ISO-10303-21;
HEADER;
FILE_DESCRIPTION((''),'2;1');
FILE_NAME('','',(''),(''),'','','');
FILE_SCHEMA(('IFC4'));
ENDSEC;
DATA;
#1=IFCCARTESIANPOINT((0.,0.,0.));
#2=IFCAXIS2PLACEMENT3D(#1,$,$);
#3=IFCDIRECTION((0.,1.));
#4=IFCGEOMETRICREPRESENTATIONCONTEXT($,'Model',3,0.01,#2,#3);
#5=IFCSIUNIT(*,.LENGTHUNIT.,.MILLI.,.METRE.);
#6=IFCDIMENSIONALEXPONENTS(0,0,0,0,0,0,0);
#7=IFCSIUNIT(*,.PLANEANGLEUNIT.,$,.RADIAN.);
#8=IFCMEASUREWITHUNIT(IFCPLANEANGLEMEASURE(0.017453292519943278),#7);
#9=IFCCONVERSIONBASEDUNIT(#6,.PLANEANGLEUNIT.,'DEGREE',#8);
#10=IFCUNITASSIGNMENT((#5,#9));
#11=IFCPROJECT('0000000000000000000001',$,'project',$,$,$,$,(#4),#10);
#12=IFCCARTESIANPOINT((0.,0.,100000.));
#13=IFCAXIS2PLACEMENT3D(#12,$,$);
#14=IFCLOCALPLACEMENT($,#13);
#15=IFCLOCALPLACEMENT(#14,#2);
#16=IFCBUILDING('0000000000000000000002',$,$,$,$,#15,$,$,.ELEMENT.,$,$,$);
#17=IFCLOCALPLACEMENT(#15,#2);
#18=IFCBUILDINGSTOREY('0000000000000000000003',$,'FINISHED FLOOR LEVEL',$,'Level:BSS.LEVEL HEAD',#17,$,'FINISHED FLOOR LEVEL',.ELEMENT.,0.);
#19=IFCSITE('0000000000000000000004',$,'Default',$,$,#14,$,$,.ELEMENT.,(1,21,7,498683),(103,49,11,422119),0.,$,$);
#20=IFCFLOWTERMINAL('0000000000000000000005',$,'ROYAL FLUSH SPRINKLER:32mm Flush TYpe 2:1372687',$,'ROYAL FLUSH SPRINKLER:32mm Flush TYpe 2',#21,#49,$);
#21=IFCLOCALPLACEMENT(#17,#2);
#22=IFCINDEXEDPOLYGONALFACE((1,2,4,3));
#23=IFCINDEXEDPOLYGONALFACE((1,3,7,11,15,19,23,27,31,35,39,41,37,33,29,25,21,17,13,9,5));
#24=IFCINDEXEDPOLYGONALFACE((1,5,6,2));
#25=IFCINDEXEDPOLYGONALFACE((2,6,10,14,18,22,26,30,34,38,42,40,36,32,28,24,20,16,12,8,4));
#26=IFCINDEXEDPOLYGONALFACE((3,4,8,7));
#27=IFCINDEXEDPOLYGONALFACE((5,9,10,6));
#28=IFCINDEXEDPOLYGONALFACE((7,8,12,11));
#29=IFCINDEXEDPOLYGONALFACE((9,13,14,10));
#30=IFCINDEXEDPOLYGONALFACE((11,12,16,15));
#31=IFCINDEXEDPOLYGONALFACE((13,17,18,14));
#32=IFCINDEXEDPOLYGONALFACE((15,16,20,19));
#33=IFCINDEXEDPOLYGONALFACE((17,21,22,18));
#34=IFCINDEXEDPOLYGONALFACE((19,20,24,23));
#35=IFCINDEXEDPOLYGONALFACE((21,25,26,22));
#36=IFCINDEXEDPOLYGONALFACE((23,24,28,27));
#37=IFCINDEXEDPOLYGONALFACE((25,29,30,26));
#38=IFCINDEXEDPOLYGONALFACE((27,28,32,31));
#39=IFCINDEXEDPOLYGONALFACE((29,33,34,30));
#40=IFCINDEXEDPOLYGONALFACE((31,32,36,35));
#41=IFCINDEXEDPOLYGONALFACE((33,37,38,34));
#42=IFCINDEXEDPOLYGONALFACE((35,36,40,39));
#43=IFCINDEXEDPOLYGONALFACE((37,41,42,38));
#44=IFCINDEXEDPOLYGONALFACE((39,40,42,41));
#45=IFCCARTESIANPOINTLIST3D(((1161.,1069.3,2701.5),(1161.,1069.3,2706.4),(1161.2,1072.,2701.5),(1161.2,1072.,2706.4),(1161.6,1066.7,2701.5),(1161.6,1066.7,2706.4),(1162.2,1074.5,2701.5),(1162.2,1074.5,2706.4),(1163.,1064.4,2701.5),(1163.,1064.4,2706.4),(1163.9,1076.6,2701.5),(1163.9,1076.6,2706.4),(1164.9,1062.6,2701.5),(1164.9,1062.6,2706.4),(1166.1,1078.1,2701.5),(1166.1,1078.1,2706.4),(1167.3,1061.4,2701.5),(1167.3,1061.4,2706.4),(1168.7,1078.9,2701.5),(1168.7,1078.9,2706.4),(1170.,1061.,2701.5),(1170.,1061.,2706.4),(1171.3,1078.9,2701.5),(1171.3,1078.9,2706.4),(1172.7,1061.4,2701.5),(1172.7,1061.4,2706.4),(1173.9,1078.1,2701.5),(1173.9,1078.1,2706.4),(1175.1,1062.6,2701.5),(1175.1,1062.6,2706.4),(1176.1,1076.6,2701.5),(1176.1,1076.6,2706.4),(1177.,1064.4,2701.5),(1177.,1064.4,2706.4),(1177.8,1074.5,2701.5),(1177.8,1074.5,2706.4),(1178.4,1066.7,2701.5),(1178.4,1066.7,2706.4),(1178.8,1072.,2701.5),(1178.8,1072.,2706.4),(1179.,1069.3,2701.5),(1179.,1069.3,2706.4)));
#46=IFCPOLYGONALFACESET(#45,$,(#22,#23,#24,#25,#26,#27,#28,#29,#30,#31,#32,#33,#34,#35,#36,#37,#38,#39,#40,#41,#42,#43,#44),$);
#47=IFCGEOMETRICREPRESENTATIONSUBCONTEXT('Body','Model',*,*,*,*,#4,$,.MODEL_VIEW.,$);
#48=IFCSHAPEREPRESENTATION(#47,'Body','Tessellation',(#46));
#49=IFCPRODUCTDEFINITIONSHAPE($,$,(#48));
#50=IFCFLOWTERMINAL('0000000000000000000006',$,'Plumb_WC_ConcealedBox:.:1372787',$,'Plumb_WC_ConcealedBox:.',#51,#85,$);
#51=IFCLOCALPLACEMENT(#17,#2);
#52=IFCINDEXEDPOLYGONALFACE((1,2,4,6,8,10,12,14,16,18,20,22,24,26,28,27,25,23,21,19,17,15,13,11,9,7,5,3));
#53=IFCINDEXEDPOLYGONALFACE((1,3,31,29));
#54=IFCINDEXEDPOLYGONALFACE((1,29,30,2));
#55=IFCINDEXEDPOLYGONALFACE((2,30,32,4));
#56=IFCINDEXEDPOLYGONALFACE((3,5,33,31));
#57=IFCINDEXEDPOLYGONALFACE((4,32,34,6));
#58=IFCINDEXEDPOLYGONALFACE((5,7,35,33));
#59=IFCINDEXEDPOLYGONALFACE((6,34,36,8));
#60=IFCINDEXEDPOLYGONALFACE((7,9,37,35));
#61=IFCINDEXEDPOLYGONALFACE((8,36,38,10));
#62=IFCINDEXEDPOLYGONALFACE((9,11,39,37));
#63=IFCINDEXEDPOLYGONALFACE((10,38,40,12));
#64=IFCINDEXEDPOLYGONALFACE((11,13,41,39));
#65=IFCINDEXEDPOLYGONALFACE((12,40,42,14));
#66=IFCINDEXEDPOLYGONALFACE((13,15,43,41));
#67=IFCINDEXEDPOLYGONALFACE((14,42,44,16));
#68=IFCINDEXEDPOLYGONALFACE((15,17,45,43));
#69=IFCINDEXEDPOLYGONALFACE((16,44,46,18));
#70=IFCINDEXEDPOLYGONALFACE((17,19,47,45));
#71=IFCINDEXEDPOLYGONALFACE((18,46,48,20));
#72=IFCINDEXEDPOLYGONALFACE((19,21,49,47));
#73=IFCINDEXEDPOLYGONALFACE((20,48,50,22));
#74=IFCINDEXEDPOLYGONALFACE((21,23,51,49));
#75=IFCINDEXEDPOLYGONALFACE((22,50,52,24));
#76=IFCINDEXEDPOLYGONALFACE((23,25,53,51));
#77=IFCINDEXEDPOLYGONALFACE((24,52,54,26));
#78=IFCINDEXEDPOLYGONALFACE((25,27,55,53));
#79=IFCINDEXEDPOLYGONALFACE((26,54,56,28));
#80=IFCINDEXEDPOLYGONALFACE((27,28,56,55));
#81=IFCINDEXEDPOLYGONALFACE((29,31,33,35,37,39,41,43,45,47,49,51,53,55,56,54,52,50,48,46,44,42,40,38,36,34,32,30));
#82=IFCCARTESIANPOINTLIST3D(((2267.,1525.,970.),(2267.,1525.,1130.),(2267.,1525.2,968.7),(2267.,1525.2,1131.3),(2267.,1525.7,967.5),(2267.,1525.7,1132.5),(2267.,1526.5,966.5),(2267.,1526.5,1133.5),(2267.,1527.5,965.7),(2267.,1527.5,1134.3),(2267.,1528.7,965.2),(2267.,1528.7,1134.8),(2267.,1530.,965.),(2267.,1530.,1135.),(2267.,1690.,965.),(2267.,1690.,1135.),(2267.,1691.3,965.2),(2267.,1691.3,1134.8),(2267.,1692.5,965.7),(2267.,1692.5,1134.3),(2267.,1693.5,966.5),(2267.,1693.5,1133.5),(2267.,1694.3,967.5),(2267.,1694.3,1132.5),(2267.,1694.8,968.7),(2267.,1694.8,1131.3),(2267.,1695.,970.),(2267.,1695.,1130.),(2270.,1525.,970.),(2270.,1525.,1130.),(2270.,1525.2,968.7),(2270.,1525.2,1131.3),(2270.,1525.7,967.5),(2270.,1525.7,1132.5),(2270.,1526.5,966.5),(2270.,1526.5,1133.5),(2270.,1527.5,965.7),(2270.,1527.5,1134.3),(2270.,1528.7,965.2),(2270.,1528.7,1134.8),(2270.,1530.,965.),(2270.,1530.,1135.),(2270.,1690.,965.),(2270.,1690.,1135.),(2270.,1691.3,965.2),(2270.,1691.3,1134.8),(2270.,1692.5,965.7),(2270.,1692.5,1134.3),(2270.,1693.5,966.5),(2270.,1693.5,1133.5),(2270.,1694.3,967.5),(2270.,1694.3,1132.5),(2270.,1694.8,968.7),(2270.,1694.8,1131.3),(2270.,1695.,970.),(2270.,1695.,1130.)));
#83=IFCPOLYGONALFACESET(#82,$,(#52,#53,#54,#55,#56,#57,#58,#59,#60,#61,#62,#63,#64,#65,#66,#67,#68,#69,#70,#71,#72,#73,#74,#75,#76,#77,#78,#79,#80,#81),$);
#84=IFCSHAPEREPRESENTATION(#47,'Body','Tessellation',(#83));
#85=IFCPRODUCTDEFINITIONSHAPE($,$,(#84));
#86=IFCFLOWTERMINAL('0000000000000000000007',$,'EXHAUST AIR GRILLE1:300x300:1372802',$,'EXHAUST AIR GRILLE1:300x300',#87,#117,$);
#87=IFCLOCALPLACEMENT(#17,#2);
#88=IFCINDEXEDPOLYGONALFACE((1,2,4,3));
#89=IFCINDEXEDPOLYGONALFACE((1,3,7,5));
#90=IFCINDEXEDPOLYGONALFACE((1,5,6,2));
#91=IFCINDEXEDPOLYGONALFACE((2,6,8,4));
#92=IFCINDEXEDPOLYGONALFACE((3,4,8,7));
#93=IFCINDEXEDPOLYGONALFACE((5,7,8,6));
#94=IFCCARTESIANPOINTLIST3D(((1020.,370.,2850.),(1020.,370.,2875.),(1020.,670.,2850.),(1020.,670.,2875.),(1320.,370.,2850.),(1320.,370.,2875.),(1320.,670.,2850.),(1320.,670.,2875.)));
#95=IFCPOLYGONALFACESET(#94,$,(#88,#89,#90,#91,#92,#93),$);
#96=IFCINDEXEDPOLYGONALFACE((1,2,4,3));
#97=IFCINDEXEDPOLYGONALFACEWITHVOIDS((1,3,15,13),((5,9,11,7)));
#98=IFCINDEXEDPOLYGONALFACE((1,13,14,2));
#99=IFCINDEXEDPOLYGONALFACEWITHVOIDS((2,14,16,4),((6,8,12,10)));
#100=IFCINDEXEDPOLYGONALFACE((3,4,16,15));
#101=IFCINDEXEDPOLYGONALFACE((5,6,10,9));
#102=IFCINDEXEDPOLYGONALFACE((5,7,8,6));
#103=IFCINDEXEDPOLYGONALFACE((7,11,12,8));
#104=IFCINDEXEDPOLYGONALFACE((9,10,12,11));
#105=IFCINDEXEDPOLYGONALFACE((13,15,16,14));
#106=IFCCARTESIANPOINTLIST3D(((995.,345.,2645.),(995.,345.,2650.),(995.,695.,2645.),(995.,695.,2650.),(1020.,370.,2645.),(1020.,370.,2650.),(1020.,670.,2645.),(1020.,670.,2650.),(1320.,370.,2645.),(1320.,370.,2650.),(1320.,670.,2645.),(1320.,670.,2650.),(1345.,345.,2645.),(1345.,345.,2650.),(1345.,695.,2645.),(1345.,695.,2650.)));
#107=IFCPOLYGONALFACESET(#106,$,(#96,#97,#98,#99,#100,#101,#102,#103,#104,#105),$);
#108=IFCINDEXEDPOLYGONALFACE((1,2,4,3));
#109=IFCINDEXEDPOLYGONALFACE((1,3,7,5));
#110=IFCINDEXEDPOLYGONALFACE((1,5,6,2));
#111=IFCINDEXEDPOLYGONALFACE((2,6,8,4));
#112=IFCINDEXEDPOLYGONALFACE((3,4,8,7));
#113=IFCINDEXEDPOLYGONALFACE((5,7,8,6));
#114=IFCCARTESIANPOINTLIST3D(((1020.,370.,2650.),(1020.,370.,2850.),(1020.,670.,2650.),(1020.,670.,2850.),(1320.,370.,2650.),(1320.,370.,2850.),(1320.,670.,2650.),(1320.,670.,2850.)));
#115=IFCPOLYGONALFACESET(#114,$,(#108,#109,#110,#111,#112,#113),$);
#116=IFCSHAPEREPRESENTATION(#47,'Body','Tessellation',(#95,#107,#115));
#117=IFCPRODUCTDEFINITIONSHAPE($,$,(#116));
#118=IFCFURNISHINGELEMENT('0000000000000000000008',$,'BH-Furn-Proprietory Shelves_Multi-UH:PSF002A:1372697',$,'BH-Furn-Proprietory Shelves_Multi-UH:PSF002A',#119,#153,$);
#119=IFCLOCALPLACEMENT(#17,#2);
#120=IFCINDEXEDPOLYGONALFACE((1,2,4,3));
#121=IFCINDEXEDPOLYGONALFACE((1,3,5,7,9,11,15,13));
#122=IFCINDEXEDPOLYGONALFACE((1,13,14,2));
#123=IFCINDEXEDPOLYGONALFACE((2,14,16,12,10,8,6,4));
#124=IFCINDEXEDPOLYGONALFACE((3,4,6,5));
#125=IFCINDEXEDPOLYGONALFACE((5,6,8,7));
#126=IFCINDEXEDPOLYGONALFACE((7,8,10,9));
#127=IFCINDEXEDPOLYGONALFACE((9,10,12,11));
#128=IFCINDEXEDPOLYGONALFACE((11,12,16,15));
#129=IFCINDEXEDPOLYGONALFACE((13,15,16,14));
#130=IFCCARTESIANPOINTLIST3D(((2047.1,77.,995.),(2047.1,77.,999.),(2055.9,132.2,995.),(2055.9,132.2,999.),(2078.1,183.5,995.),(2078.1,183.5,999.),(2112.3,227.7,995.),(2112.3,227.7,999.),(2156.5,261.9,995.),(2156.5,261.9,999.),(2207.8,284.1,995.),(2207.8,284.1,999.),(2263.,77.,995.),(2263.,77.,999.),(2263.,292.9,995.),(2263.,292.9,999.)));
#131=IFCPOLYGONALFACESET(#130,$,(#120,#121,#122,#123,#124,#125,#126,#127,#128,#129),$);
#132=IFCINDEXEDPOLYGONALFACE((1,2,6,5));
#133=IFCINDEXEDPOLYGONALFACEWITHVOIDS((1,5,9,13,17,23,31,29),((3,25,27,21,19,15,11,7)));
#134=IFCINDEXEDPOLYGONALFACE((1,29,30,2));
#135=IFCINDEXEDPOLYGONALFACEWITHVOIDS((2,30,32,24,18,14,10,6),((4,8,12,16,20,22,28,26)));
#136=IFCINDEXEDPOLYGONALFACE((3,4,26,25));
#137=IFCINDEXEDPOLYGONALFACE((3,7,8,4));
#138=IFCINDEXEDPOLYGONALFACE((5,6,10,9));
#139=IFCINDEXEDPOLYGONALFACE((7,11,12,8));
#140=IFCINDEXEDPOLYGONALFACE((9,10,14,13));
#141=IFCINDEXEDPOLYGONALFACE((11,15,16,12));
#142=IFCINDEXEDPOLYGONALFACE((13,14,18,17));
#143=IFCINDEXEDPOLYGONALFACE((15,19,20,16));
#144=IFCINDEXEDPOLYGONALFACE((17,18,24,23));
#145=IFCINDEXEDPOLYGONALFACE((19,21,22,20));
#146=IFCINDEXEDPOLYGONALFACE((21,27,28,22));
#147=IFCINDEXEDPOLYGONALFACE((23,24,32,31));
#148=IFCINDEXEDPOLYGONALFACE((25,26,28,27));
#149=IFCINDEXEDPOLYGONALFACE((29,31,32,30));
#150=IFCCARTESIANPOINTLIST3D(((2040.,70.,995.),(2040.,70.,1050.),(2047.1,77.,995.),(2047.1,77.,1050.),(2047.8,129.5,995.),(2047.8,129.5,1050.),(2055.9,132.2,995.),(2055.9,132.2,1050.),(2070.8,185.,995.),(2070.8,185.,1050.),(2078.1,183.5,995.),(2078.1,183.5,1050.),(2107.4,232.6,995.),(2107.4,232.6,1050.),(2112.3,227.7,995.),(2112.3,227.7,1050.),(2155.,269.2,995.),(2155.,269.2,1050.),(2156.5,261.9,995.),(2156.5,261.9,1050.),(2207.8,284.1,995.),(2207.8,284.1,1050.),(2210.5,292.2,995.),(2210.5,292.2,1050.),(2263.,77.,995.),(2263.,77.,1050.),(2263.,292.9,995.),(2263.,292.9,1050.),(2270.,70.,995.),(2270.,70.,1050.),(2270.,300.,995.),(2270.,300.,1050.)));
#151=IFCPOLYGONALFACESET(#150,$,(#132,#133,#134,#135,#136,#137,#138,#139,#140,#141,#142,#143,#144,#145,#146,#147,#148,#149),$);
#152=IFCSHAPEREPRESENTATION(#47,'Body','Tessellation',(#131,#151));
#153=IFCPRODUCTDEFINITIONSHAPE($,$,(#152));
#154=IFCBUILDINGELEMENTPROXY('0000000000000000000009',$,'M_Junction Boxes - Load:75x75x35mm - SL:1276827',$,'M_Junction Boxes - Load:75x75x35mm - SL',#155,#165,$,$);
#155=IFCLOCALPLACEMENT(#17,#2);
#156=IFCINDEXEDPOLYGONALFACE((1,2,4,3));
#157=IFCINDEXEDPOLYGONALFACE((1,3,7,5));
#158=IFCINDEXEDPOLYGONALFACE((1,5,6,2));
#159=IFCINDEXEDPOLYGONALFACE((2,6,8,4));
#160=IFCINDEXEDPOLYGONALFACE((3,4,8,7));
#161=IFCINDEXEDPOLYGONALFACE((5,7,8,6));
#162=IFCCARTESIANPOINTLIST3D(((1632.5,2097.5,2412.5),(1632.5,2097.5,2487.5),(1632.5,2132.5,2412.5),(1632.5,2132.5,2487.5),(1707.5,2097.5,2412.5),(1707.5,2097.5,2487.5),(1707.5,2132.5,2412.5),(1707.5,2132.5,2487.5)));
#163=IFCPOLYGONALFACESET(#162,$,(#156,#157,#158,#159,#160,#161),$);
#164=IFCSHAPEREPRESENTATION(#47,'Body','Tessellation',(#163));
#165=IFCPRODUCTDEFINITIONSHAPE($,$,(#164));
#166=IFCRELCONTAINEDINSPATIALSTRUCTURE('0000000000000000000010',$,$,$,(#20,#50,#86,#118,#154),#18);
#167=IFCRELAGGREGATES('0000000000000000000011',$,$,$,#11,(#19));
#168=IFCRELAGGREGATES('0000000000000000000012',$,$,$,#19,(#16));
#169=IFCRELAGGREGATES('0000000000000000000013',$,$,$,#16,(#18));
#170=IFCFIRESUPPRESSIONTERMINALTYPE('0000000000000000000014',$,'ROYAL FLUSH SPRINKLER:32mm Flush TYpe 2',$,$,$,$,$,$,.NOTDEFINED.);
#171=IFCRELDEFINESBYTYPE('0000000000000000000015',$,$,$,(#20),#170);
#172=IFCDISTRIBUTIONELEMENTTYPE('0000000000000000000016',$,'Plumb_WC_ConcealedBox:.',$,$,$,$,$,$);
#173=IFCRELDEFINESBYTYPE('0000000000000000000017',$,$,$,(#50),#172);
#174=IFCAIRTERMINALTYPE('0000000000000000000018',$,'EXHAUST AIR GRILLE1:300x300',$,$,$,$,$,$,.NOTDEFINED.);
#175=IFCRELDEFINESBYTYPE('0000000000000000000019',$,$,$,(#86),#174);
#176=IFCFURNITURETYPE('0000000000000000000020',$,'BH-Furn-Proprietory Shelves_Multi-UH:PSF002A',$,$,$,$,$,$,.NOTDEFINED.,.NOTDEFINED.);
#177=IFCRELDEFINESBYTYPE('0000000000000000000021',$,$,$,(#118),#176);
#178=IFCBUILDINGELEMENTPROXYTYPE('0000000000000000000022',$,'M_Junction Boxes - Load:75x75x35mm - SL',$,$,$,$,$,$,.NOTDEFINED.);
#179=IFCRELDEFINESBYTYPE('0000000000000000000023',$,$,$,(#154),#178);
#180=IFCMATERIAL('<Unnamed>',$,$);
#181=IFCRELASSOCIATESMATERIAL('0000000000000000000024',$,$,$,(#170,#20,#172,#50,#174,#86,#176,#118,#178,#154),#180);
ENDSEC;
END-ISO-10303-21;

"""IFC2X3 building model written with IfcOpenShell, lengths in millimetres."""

from ifc_helpers import new_model, entity, si_unit, converted_unit, direction, frame, frame_2d, origin, origin_2d_with_axis, place, context, subcontext, project, spatial, polyline, circle_curve, parameter, trimmed, segment, composite_curve, rectangle, circle, outline, extrude, source, transform, mapped, material, type_object, type_shapes, element, save


model = new_model("IFC2X3")

# Units and contexts
model_context = context("Model", 3, precision=0.01, world=origin(), true_north=direction((0.0, 1.0)))
body_context = subcontext(model_context, "Body", "Model", "MODEL_VIEW")
ifc_project = project(units=[si_unit("LENGTHUNIT", "METRE", prefix="MILLI"), converted_unit("PLANEANGLEUNIT", "DEGREE", entity("IfcPlaneAngleMeasure", 0.017453292519943278), si_unit("PLANEANGLEUNIT", "RADIAN"), dimensions=[0, 0, 0, 0, 0, 0, 0])], contexts=[model_context])

# Site, building, storey
site_placement = place(None, frame((0.0, 0.0, 100000.0)))
site = spatial("IfcSite", under=ifc_project, at=site_placement, Name="Default", CompositionType="ELEMENT", RefLatitude=(1, 21, 7, 498683), RefLongitude=(103, 49, 11, 422119), RefElevation=0.0)
building_placement = place(site_placement, origin())
building = spatial("IfcBuilding", under=site, at=building_placement, CompositionType="ELEMENT")
storey_placement = place(building_placement, origin())
storey = spatial("IfcBuildingStorey", under=building, at=storey_placement, Name="FINISHED FLOOR LEVEL", ObjectType="Level:BSS.LEVEL HEAD", LongName="FINISHED FLOOR LEVEL", CompositionType="ELEMENT", Elevation=0.0)

# Shared definitions
ifc_material_1 = material(Name="<Unnamed>")

# Flow terminals
fire_suppression_terminal_type = type_object("IfcFireSuppressionTerminalType", Name="ROYAL FLUSH SPRINKLER:32mm Flush TYpe 2", PredefinedType="NOTDEFINED", material=ifc_material_1)
shared_shape_1 = source(origin(), body_context, "Body", "SweptSolid", [
    extrude(circle(Radius=9.0, at=frame_2d((0.0, 0.0), x_axis=(1.0, 0.0))), frame((0.0, 0.0, 0.0), z_axis=(0.0, 0.0, 1.0), x_axis=(0.0, -1.0, 0.0)), (0.0, 0.0, 1.0), 5.0),
])
type_shapes(fire_suppression_terminal_type, [shared_shape_1])
flow_terminal_1_placement = place(storey_placement, frame((1170.0, 1070.0, 2701.5)))
element("IfcFlowTerminal", 1, at=flow_terminal_1_placement, inside=storey, type_object=fire_suppression_terminal_type, material=ifc_material_1, Name="ROYAL FLUSH SPRINKLER:32mm Flush TYpe 2:1372687", ObjectType="ROYAL FLUSH SPRINKLER:32mm Flush TYpe 2", context=body_context, shape_type="MappedRepresentation", body=[
    mapped(shared_shape_1, transform((0.0, 0.0, 0.0), scale=1.0)),
])
distribution_element_type_1 = type_object("IfcDistributionElementType", Name="Plumb_WC_ConcealedBox:.", material=ifc_material_1)
shared_shape_2 = source(origin(), body_context, "Body", "SweptSolid", [
    extrude(outline(composite_curve([segment(trimmed(circle_curve(frame_2d((80.0, -80.0), x_axis=(1.0, 0.0)), 5.0), [parameter(270.0)], [parameter(0.0)], True, "PARAMETER"), True, "CONTINUOUS"), segment(polyline([(85.0, -80.0), (85.0, 80.0)]), True, "CONTINUOUS"), segment(trimmed(circle_curve(frame_2d((80.0, 80.0), x_axis=(1.0, 0.0)), 5.0), [parameter(0.0)], [parameter(90.0)], True, "PARAMETER"), True, "CONTINUOUS"), segment(polyline([(80.0, 85.0), (-80.0, 85.0)]), True, "CONTINUOUS"), segment(trimmed(circle_curve(frame_2d((-80.0, 80.0), x_axis=(1.0, 0.0)), 5.0), [parameter(90.0)], [parameter(180.0)], True, "PARAMETER"), True, "CONTINUOUS"), segment(polyline([(-85.0, 80.0), (-85.0, -80.0)]), True, "CONTINUOUS"), segment(trimmed(circle_curve(frame_2d((-80.0, -80.0), x_axis=(1.0, 0.0)), 5.0), [parameter(180.0)], [parameter(270.0)], True, "PARAMETER"), True, "CONTINUOUS"), segment(polyline([(-80.0, -85.0), (80.0, -85.0)]), True, "CONTINUOUS")], self_intersect=False)), frame((0.0, -3.0, 1050.0), z_axis=(0.0, 1.0, 0.0), x_axis=(1.0, 0.0, 0.0)), (0.0, 0.0, 1.0), 3.0),
])
type_shapes(distribution_element_type_1, [shared_shape_2])
flow_terminal_2_placement = place(storey_placement, frame((2270.0, 1610.0, 0.0), z_axis=(0.0, 0.0, 1.0), x_axis=(0.0, -1.0, 0.0)))
element("IfcFlowTerminal", 2, at=flow_terminal_2_placement, inside=storey, type_object=distribution_element_type_1, material=ifc_material_1, Name="Plumb_WC_ConcealedBox:.:1372787", ObjectType="Plumb_WC_ConcealedBox:.", context=body_context, shape_type="MappedRepresentation", body=[
    mapped(shared_shape_2, transform((0.0, 0.0, 0.0), scale=1.0)),
])
air_terminal_type_1 = type_object("IfcAirTerminalType", Name="EXHAUST AIR GRILLE1:300x300", PredefinedType="NOTDEFINED", material=ifc_material_1)
shared_shape_3 = source(origin(), body_context, "Body", "SweptSolid", [
    extrude(rectangle(XDim=300.0, YDim=300.0, at=origin_2d_with_axis()), frame((0.0, 0.0, 200.0), z_axis=(0.0, 0.0, 1.0), x_axis=(-1.0, 0.0, 0.0)), (0.0, 0.0, 1.0), 25.0),
    extrude(outline(polyline([(-175.0, -175.0), (175.0, -175.0), (175.0, 175.0), (-175.0, 175.0), (-175.0, -175.0)]), holes=[polyline([(-150.0, -150.0), (-150.0, 150.0), (150.0, 150.0), (150.0, -150.0), (-150.0, -150.0)])]), frame((0.0, 0.0, -5.0), z_axis=(0.0, 0.0, 1.0), x_axis=(-1.0, 0.0, 0.0)), (0.0, 0.0, 1.0), 5.0),
    extrude(rectangle(XDim=300.0, YDim=300.0, at=origin_2d_with_axis()), frame((0.0, 0.0, 0.0), z_axis=(0.0, 0.0, 1.0), x_axis=(-1.0, 0.0, 0.0)), (0.0, 0.0, 1.0), 200.0),
])
type_shapes(air_terminal_type_1, [shared_shape_3])
flow_terminal_3_placement = place(storey_placement, frame((1170.0, 520.0, 2650.0)))
element("IfcFlowTerminal", 3, at=flow_terminal_3_placement, inside=storey, type_object=air_terminal_type_1, material=ifc_material_1, Name="EXHAUST AIR GRILLE1:300x300:1372802", ObjectType="EXHAUST AIR GRILLE1:300x300", context=body_context, shape_type="MappedRepresentation", body=[
    mapped(shared_shape_3, transform((0.0, 0.0, 0.0), scale=1.0)),
])

# Furnishing element
furniture_type_1 = type_object("IfcFurnitureType", Name="BH-Furn-Proprietory Shelves_Multi-UH:PSF002A", AssemblyPlace="NOTDEFINED", material=ifc_material_1)
shared_shape_4 = source(origin(), body_context, "Body", "SweptSolid", [
    extrude(outline(composite_curve([segment(polyline([(-143.9, -72.0), (72.0, -72.0)]), True, "CONTINUOUS"), segment(polyline([(72.0, -72.0), (72.0, 143.9)]), True, "CONTINUOUS"), segment(trimmed(circle_curve(frame_2d((79.0, -79.0), x_axis=(1.0, 0.0)), 223.0), [parameter(91.798818)], [parameter(178.201182)], True, "PARAMETER"), True, "CONTINUOUS")], self_intersect=False)), frame((79.0, -79.0, 995.0), z_axis=(0.0, 0.0, 1.0), x_axis=(-1.0, 0.0, 0.0)), (0.0, 0.0, 1.0), 4.0),
    extrude(outline(composite_curve([segment(polyline([(-153.3, -76.7), (76.7, -76.7)]), True, "CONTINUOUS"), segment(polyline([(76.7, -76.7), (76.7, 153.3)]), True, "CONTINUOUS"), segment(trimmed(circle_curve(frame_2d((76.7, -76.7), x_axis=(1.0, 0.0)), 230.0), [parameter(90.0)], [parameter(180.0)], True, "PARAMETER"), True, "CONTINUOUS")], self_intersect=False), holes=[composite_curve([segment(trimmed(circle_curve(frame_2d((76.7, -76.7), x_axis=(1.0, 0.0)), 223.0), [parameter(91.798818)], [parameter(178.201182)], True, "PARAMETER"), False, "CONTINUOUS"), segment(polyline([(69.7, 146.2), (69.7, -69.7)]), True, "CONTINUOUS"), segment(polyline([(69.7, -69.7), (-146.2, -69.7)]), True, "CONTINUOUS")], self_intersect=False)]), frame((76.7, -76.7, 995.0), z_axis=(0.0, 0.0, 1.0), x_axis=(-1.0, 0.0, 0.0)), (0.0, 0.0, 1.0), 55.0),
])
type_shapes(furniture_type_1, [shared_shape_4])
furnishing_1_placement = place(storey_placement, frame((2270.0, 70.0, 0.0), z_axis=(0.0, 0.0, 1.0), x_axis=(-1.0, 0.0, 0.0)))
element("IfcFurnishingElement", 4, at=furnishing_1_placement, inside=storey, type_object=furniture_type_1, material=ifc_material_1, Name="BH-Furn-Proprietory Shelves_Multi-UH:PSF002A:1372697", ObjectType="BH-Furn-Proprietory Shelves_Multi-UH:PSF002A", context=body_context, shape_type="MappedRepresentation", body=[
    mapped(shared_shape_4, transform((0.0, 0.0, 0.0), scale=1.0)),
])

# Building element proxy
building_element_proxy_type_1 = type_object("IfcBuildingElementProxyType", Name="M_Junction Boxes - Load:75x75x35mm - SL", PredefinedType="NOTDEFINED", material=ifc_material_1)
shared_shape_5 = source(origin(), body_context, "Body", "SweptSolid", [
    extrude(rectangle(XDim=35.0, YDim=75.0, at=origin_2d_with_axis()), frame((0.0, 0.0, 0.0), z_axis=(0.0, 0.0, 1.0), x_axis=(0.0, 1.0, 0.0)), (0.0, 0.0, 1.0), 75.0),
])
type_shapes(building_element_proxy_type_1, [shared_shape_5])
proxy_1_placement = place(storey_placement, frame((1670.0, 2115.0, 2412.5)))
element("IfcBuildingElementProxy", 5, at=proxy_1_placement, inside=storey, type_object=building_element_proxy_type_1, material=ifc_material_1, Name="M_Junction Boxes - Load:75x75x35mm - SL:1276827", ObjectType="M_Junction Boxes - Load:75x75x35mm - SL", context=body_context, shape_type="MappedRepresentation", body=[
    mapped(shared_shape_5, transform((0.0, 0.0, 0.0), scale=1.0)),
])

save(model, "model.ifc")
